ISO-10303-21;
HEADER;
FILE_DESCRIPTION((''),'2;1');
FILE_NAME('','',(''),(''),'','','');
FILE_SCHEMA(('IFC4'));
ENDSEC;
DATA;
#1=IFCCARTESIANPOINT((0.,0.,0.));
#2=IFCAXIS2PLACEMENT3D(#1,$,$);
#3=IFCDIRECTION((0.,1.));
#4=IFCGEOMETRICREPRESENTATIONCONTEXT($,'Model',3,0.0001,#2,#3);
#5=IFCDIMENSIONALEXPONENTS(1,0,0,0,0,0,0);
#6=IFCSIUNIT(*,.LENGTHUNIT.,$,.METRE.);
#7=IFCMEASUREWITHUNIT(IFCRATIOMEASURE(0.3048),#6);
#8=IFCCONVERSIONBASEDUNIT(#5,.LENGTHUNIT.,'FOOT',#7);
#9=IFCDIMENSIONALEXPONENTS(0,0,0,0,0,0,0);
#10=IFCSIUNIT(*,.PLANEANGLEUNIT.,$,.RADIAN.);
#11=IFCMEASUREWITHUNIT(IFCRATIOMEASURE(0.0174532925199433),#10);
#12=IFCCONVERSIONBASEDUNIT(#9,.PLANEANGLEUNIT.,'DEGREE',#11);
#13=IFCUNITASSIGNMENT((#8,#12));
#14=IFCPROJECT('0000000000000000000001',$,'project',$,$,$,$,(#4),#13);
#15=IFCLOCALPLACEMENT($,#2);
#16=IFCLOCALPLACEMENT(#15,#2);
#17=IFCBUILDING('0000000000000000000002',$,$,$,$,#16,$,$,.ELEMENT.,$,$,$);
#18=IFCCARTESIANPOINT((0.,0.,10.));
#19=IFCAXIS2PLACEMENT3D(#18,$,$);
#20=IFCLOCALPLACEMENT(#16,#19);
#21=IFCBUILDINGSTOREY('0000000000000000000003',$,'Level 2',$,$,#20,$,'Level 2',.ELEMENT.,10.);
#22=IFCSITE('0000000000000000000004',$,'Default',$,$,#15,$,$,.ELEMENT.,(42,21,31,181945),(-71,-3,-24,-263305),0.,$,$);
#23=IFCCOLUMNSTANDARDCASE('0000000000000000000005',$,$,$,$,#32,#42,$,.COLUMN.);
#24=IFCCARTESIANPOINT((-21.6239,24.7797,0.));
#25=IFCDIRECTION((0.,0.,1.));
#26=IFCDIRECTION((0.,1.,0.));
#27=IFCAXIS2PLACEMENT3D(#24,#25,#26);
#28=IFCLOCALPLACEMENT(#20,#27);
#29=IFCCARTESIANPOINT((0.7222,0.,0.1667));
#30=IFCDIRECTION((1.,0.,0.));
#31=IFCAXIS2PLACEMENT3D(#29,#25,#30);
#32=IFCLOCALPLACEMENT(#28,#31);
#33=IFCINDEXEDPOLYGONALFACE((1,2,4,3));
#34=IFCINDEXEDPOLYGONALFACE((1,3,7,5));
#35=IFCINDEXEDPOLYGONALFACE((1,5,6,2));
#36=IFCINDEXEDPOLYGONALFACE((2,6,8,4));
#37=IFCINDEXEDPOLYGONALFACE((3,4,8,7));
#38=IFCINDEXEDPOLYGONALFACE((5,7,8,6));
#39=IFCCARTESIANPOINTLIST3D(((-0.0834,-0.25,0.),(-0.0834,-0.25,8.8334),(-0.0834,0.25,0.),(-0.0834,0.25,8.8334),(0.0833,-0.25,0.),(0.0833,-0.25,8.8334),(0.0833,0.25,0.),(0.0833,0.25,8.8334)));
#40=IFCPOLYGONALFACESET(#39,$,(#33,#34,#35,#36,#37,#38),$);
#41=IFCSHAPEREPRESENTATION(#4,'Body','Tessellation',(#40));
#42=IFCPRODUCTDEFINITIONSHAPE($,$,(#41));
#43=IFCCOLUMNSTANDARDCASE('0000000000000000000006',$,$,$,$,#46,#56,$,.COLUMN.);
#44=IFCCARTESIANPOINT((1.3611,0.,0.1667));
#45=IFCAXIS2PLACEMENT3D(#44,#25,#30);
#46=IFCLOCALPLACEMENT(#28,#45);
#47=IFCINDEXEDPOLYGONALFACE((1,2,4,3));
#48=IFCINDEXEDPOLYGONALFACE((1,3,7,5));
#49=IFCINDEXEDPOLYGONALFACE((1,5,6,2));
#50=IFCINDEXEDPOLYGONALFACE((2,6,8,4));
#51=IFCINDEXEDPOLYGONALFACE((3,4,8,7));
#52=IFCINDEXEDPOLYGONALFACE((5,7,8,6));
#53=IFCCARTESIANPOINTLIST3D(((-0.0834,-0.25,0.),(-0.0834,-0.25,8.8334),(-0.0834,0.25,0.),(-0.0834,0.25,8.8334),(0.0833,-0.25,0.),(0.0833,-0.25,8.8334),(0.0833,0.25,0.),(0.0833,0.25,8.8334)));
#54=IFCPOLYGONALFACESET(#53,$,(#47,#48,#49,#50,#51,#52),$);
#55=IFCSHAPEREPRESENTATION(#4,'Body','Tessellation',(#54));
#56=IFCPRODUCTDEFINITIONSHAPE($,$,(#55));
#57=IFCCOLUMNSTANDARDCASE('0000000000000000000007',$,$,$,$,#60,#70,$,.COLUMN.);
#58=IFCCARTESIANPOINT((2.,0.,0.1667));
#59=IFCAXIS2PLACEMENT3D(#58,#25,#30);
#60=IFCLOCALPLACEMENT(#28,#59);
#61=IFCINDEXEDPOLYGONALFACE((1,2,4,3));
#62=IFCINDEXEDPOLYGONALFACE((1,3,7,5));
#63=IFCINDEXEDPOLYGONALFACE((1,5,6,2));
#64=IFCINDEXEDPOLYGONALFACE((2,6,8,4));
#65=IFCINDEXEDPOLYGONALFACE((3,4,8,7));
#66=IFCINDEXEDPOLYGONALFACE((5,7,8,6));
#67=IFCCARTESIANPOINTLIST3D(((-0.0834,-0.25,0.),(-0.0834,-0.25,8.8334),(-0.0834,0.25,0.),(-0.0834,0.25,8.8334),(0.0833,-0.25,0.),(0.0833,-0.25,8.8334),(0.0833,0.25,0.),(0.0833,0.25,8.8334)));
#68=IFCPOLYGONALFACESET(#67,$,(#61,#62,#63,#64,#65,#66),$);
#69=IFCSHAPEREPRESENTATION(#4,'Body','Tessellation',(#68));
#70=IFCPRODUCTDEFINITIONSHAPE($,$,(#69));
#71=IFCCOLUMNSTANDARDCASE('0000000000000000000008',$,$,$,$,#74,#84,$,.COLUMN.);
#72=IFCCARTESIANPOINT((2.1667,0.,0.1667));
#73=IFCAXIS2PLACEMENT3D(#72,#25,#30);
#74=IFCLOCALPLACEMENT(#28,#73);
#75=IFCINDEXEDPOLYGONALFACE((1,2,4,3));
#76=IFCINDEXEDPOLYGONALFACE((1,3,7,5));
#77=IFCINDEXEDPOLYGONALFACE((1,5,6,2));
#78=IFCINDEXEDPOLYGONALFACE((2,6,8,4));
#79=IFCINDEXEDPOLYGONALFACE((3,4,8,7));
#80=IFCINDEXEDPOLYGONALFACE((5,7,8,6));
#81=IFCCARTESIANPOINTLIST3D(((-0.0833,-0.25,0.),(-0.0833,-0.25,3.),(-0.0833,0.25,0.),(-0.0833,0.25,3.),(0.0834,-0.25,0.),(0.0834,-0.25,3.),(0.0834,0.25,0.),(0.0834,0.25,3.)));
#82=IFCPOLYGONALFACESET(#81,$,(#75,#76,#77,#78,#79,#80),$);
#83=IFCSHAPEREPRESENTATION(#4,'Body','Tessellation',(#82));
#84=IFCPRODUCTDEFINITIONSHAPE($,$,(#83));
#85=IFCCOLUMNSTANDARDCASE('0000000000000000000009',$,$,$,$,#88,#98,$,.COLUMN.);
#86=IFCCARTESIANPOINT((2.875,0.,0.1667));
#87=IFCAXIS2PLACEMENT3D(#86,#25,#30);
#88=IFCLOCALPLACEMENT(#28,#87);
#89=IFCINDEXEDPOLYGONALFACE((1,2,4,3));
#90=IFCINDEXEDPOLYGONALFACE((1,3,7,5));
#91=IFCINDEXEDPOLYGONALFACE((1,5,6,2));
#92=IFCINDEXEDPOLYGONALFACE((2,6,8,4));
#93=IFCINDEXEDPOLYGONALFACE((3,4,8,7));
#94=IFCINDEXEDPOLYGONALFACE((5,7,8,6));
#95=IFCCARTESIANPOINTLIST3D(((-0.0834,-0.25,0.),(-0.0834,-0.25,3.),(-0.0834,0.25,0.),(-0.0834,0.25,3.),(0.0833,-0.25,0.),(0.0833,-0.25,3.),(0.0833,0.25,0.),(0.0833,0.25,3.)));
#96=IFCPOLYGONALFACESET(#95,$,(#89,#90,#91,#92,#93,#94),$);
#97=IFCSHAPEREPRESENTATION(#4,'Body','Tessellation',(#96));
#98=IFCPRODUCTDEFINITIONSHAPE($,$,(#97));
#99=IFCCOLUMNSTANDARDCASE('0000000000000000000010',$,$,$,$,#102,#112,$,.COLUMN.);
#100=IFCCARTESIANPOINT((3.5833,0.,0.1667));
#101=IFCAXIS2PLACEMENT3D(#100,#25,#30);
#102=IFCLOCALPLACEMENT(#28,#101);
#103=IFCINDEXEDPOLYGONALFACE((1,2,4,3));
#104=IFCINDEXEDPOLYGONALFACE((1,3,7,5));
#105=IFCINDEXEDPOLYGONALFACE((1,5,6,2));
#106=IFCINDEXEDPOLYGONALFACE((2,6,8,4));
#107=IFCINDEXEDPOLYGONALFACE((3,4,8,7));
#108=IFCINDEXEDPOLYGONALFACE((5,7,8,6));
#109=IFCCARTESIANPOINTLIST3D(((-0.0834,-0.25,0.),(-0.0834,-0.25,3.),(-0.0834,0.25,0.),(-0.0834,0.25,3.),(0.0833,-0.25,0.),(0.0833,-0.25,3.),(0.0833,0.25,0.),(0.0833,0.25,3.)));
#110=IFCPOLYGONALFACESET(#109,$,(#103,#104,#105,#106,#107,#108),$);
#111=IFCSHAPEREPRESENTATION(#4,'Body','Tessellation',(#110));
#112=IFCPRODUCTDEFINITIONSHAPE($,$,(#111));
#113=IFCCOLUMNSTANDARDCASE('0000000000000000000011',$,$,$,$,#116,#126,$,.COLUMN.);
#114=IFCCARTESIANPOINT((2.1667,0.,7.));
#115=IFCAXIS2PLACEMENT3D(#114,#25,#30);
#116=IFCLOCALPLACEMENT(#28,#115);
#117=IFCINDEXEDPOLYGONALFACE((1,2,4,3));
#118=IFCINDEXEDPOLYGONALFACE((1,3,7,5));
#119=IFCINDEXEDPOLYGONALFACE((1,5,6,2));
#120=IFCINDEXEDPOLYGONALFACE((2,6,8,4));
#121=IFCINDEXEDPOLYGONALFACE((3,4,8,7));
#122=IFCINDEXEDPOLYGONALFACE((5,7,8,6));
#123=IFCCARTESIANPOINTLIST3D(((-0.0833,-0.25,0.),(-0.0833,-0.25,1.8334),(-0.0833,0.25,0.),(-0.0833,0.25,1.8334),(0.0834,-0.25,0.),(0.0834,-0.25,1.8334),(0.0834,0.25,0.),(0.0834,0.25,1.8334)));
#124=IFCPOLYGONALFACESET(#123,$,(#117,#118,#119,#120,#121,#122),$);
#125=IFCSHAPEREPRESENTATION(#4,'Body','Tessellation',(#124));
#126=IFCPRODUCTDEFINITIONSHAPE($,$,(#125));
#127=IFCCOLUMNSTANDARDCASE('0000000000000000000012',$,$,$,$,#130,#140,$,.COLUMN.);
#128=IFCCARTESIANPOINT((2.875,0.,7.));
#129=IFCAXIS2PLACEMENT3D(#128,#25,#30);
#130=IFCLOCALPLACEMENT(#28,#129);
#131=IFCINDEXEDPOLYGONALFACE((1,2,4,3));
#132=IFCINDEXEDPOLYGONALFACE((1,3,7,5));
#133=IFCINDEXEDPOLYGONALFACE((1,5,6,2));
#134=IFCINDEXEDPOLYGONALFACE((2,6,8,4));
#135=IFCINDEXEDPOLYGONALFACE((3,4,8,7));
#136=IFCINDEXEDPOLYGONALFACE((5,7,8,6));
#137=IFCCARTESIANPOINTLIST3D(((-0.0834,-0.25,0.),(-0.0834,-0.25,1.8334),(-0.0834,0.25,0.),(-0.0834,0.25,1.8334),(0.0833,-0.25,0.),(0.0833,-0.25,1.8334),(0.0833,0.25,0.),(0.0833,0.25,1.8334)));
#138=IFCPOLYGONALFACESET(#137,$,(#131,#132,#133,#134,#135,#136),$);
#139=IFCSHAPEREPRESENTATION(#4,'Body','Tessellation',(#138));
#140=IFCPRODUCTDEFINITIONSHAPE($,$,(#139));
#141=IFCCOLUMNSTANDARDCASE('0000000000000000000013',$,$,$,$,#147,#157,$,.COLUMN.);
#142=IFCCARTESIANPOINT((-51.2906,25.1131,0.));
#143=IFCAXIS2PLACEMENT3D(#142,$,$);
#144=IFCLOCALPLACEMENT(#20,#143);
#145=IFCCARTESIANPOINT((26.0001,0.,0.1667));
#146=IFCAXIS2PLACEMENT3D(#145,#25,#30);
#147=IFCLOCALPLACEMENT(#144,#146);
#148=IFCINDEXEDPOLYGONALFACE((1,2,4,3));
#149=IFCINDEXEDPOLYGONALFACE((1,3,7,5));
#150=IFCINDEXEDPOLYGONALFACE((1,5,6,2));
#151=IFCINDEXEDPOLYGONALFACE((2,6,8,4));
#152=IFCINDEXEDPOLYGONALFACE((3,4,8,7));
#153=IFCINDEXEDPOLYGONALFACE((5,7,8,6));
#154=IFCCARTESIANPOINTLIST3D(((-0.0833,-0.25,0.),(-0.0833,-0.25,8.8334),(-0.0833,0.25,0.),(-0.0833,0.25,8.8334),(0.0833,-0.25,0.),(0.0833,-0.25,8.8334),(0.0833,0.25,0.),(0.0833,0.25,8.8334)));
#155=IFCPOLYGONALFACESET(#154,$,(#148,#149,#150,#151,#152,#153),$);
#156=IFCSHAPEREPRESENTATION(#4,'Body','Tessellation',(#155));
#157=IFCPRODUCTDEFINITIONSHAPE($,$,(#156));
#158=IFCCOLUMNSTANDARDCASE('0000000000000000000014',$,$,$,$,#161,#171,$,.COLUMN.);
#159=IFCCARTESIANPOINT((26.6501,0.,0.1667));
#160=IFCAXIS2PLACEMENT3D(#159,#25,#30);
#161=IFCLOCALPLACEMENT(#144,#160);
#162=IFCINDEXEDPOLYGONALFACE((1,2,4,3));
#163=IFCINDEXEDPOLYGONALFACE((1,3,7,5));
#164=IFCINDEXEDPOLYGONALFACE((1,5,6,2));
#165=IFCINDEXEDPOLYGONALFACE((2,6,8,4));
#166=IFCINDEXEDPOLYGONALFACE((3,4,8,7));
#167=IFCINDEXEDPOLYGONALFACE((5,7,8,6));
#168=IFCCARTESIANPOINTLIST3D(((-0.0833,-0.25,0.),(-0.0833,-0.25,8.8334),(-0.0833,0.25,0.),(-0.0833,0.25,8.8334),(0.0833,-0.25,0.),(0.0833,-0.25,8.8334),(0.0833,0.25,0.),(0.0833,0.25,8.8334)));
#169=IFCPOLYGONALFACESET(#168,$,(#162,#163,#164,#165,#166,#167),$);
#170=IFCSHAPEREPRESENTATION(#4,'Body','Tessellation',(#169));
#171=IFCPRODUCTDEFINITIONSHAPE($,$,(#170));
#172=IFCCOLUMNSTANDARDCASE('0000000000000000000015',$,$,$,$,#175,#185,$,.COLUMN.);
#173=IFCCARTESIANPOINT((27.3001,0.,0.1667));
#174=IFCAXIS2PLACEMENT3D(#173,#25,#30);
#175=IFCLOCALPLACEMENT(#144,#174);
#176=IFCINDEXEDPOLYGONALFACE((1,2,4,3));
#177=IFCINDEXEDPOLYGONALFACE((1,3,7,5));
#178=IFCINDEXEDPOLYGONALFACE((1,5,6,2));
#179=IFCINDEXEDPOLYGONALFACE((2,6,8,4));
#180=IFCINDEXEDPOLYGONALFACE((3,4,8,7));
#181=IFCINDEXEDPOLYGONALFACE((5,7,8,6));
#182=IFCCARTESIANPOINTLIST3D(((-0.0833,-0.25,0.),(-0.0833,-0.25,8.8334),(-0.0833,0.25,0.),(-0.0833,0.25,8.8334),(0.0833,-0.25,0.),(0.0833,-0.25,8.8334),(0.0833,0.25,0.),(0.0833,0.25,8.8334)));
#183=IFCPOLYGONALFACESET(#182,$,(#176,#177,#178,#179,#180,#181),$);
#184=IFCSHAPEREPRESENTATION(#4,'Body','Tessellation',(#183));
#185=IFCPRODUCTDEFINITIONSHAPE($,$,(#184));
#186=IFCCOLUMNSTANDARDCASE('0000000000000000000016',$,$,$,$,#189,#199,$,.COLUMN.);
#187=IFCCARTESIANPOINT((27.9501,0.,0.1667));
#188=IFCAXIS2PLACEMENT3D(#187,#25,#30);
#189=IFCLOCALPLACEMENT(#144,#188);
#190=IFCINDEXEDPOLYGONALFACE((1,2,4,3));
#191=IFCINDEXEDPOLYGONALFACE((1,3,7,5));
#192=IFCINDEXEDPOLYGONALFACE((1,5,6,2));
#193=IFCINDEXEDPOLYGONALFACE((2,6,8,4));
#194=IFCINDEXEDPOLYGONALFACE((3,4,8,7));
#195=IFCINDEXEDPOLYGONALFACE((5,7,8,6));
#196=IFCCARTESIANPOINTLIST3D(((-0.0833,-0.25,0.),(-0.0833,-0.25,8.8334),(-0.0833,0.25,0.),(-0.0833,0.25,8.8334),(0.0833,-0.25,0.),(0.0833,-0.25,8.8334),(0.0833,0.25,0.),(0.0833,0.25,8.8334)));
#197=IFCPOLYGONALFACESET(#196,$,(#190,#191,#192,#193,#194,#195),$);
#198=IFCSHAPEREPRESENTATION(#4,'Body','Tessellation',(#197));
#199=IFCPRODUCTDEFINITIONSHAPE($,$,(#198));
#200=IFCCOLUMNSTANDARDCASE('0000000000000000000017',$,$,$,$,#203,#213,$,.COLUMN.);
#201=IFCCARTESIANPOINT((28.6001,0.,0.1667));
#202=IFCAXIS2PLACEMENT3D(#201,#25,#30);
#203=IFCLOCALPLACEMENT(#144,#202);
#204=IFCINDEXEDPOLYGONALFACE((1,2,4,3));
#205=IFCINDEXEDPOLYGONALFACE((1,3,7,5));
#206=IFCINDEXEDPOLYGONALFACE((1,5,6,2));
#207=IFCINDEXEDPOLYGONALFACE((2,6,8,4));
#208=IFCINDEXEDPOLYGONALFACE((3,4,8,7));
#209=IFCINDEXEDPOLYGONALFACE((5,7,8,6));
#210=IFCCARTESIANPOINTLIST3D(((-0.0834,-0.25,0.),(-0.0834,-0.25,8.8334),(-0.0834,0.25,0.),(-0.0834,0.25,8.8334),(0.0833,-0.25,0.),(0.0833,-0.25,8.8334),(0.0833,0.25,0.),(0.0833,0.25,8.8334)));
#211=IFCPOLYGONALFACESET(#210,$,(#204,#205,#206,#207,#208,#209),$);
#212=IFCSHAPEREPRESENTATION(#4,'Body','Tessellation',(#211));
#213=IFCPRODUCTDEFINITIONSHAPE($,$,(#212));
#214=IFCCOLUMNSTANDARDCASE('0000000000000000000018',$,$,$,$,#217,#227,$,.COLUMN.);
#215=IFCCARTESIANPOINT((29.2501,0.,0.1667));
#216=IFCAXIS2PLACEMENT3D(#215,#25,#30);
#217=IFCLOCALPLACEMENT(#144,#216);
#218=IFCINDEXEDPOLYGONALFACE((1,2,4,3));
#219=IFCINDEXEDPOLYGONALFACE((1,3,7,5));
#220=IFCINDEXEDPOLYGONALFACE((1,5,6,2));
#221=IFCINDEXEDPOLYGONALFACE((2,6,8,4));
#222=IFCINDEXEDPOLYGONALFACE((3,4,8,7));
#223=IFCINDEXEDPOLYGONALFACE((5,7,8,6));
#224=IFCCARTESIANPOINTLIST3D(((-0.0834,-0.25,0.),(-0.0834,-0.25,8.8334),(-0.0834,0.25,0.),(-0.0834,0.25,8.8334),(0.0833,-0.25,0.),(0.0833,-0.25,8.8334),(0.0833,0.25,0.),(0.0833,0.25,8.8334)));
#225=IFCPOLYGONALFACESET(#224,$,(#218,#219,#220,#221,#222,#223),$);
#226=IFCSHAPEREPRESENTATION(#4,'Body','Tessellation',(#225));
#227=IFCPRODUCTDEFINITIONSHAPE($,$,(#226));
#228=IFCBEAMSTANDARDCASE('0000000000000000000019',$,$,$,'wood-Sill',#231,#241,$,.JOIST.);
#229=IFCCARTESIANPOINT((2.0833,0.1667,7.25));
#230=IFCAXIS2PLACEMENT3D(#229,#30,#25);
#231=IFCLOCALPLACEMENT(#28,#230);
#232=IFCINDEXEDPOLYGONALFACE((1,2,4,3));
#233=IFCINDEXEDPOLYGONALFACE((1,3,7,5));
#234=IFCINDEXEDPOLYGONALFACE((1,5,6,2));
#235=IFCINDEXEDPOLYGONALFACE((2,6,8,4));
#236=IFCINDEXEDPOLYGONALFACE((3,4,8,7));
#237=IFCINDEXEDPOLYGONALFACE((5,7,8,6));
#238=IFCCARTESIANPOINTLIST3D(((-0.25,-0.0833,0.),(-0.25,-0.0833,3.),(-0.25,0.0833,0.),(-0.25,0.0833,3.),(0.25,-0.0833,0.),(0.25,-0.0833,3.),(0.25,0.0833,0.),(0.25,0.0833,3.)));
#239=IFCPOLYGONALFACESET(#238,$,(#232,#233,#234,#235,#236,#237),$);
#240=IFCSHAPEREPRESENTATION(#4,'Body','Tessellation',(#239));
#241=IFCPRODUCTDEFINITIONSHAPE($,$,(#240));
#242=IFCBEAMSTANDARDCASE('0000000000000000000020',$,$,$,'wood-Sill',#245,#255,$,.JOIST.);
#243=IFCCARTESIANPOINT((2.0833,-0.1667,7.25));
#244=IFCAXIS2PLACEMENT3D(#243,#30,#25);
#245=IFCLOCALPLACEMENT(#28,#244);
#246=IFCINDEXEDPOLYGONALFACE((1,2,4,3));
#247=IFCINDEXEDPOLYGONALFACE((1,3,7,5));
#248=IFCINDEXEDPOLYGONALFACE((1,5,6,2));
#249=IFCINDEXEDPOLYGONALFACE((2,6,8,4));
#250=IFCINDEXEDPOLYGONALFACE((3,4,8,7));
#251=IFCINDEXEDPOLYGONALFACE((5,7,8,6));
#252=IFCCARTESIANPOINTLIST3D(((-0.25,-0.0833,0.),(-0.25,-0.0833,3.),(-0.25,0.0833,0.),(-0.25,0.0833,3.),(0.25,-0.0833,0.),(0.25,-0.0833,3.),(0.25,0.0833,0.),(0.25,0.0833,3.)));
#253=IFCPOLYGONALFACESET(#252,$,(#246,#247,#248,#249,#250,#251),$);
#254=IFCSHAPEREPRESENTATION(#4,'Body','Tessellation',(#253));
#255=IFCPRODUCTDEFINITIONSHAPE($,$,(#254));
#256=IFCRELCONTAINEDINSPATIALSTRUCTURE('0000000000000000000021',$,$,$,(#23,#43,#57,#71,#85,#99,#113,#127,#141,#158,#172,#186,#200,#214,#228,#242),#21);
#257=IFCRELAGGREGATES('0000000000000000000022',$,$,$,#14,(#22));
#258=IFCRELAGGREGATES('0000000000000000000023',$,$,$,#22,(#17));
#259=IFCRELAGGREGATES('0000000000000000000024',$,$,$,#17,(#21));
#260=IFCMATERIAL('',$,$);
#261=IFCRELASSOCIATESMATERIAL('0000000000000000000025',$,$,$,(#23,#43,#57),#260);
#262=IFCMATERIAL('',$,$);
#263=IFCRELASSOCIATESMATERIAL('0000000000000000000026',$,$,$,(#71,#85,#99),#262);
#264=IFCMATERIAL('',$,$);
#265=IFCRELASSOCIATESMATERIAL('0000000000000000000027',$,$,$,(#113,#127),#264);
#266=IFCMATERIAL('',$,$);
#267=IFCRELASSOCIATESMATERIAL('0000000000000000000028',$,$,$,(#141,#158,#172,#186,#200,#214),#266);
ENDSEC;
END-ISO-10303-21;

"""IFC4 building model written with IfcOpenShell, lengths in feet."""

from ifc_helpers import new_model, entity, si_unit, converted_unit, direction, frame, origin, origin_with_axes, place, context, project, spatial, rectangle, extrude, material, element, save


model = new_model("IFC4")

# Units and contexts
model_context = context("Model", 3, precision=0.0001, world=origin(), true_north=direction((0.0, 1.0)))
ifc_project = project(units=[converted_unit("LENGTHUNIT", "FOOT", entity("IfcRatioMeasure", 0.3048), si_unit("LENGTHUNIT", "METRE"), dimensions=[1, 0, 0, 0, 0, 0, 0]), converted_unit("PLANEANGLEUNIT", "DEGREE", entity("IfcRatioMeasure", 0.0174532925199433), si_unit("PLANEANGLEUNIT", "RADIAN"), dimensions=[0, 0, 0, 0, 0, 0, 0])], contexts=[model_context])

# Site, building, storey
site_placement = place(None, origin())
site = spatial("IfcSite", under=ifc_project, at=site_placement, Name="Default", CompositionType="ELEMENT", RefLatitude=(42, 21, 31, 181945), RefLongitude=(-71, -3, -24, -263305), RefElevation=0.0)
building_placement = place(site_placement, origin())
building = spatial("IfcBuilding", under=site, at=building_placement, CompositionType="ELEMENT")
storey_placement = place(building_placement, frame((0.0, 0.0, 10.0)))
storey = spatial("IfcBuildingStorey", under=building, at=storey_placement, Name="Level 2", LongName="Level 2", CompositionType="ELEMENT", Elevation=10.0)

# Columns
ifc_material_1 = material(Name="")
placement_1 = place(storey_placement, frame((-21.6239, 24.7797, 0.0), z_axis=(0.0, 0.0, 1.0), x_axis=(0.0, 1.0, 0.0)))
for number, where, z_axis, x_axis in (
    (1, (0.7222, 0.0, 0.1667), (0.0, 0.0, 1.0), (1.0, 0.0, 0.0)),
    (2, (1.3611, 0.0, 0.1667), (0.0, 0.0, 1.0), (1.0, 0.0, 0.0)),
    (3, (2.0, 0.0, 0.1667), (0.0, 0.0, 1.0), (1.0, 0.0, 0.0)),
):
    element("IfcColumnStandardCase", number, at=place(placement_1, frame(where, z_axis=z_axis, x_axis=x_axis)), inside=storey, material=ifc_material_1, PredefinedType="COLUMN", context=model_context, shape_type="SweptSolid", body=[
        extrude(rectangle(XDim=0.1667, YDim=0.5), origin(), (0.0, 0.0, 1.0), 8.8334),
    ])
ifc_material_2 = material(Name="")
for number, where, z_axis, x_axis in (
    (4, (2.1667, 0.0, 0.1667), (0.0, 0.0, 1.0), (1.0, 0.0, 0.0)),
    (5, (2.875, 0.0, 0.1667), (0.0, 0.0, 1.0), (1.0, 0.0, 0.0)),
    (6, (3.5833, 0.0, 0.1667), (0.0, 0.0, 1.0), (1.0, 0.0, 0.0)),
):
    element("IfcColumnStandardCase", number, at=place(placement_1, frame(where, z_axis=z_axis, x_axis=x_axis)), inside=storey, material=ifc_material_2, PredefinedType="COLUMN", context=model_context, shape_type="SweptSolid", body=[
        extrude(rectangle(XDim=0.1667, YDim=0.5), origin(), (0.0, 0.0, 1.0), 3.0),
    ])
ifc_material_3 = material(Name="")
for number, where, z_axis, x_axis in (
    (7, (2.1667, 0.0, 7.0), (0.0, 0.0, 1.0), (1.0, 0.0, 0.0)),
    (8, (2.875, 0.0, 7.0), (0.0, 0.0, 1.0), (1.0, 0.0, 0.0)),
):
    element("IfcColumnStandardCase", number, at=place(placement_1, frame(where, z_axis=z_axis, x_axis=x_axis)), inside=storey, material=ifc_material_3, PredefinedType="COLUMN", context=model_context, shape_type="SweptSolid", body=[
        extrude(rectangle(XDim=0.1667, YDim=0.5), origin(), (0.0, 0.0, 1.0), 1.8334),
    ])
ifc_material_4 = material(Name="")
placement_2 = place(storey_placement, frame((-51.2906, 25.1131, 0.0)))
for number, where, z_axis, x_axis in (
    (9, (26.0001, 0.0, 0.1667), (0.0, 0.0, 1.0), (1.0, 0.0, 0.0)),
    (10, (26.6501, 0.0, 0.1667), (0.0, 0.0, 1.0), (1.0, 0.0, 0.0)),
    (11, (27.3001, 0.0, 0.1667), (0.0, 0.0, 1.0), (1.0, 0.0, 0.0)),
    (12, (27.9501, 0.0, 0.1667), (0.0, 0.0, 1.0), (1.0, 0.0, 0.0)),
    (13, (28.6001, 0.0, 0.1667), (0.0, 0.0, 1.0), (1.0, 0.0, 0.0)),
    (14, (29.2501, 0.0, 0.1667), (0.0, 0.0, 1.0), (1.0, 0.0, 0.0)),
):
    element("IfcColumnStandardCase", number, at=place(placement_2, frame(where, z_axis=z_axis, x_axis=x_axis)), inside=storey, material=ifc_material_4, PredefinedType="COLUMN", context=model_context, shape_type="SweptSolid", body=[
        extrude(rectangle(XDim=0.1667, YDim=0.5), origin(), (0.0, 0.0, 1.0), 8.8334),
    ])

# Beams
for number, where, z_axis, x_axis in (
    (15, (2.0833, 0.1667, 7.25), (1.0, 0.0, 0.0), (0.0, 0.0, 1.0)),
    (16, (2.0833, -0.1667, 7.25), (1.0, 0.0, 0.0), (0.0, 0.0, 1.0)),
):
    element("IfcBeamStandardCase", number, at=place(placement_1, frame(where, z_axis=z_axis, x_axis=x_axis)), inside=storey, ObjectType="wood-Sill", PredefinedType="JOIST", context=model_context, shape_type="SweptSolid", body=[
        extrude(rectangle(XDim=0.5, YDim=0.1667), origin_with_axes(), (0.0, 0.0, 1.0), 3.0),
    ])

save(model, "model.ifc")
